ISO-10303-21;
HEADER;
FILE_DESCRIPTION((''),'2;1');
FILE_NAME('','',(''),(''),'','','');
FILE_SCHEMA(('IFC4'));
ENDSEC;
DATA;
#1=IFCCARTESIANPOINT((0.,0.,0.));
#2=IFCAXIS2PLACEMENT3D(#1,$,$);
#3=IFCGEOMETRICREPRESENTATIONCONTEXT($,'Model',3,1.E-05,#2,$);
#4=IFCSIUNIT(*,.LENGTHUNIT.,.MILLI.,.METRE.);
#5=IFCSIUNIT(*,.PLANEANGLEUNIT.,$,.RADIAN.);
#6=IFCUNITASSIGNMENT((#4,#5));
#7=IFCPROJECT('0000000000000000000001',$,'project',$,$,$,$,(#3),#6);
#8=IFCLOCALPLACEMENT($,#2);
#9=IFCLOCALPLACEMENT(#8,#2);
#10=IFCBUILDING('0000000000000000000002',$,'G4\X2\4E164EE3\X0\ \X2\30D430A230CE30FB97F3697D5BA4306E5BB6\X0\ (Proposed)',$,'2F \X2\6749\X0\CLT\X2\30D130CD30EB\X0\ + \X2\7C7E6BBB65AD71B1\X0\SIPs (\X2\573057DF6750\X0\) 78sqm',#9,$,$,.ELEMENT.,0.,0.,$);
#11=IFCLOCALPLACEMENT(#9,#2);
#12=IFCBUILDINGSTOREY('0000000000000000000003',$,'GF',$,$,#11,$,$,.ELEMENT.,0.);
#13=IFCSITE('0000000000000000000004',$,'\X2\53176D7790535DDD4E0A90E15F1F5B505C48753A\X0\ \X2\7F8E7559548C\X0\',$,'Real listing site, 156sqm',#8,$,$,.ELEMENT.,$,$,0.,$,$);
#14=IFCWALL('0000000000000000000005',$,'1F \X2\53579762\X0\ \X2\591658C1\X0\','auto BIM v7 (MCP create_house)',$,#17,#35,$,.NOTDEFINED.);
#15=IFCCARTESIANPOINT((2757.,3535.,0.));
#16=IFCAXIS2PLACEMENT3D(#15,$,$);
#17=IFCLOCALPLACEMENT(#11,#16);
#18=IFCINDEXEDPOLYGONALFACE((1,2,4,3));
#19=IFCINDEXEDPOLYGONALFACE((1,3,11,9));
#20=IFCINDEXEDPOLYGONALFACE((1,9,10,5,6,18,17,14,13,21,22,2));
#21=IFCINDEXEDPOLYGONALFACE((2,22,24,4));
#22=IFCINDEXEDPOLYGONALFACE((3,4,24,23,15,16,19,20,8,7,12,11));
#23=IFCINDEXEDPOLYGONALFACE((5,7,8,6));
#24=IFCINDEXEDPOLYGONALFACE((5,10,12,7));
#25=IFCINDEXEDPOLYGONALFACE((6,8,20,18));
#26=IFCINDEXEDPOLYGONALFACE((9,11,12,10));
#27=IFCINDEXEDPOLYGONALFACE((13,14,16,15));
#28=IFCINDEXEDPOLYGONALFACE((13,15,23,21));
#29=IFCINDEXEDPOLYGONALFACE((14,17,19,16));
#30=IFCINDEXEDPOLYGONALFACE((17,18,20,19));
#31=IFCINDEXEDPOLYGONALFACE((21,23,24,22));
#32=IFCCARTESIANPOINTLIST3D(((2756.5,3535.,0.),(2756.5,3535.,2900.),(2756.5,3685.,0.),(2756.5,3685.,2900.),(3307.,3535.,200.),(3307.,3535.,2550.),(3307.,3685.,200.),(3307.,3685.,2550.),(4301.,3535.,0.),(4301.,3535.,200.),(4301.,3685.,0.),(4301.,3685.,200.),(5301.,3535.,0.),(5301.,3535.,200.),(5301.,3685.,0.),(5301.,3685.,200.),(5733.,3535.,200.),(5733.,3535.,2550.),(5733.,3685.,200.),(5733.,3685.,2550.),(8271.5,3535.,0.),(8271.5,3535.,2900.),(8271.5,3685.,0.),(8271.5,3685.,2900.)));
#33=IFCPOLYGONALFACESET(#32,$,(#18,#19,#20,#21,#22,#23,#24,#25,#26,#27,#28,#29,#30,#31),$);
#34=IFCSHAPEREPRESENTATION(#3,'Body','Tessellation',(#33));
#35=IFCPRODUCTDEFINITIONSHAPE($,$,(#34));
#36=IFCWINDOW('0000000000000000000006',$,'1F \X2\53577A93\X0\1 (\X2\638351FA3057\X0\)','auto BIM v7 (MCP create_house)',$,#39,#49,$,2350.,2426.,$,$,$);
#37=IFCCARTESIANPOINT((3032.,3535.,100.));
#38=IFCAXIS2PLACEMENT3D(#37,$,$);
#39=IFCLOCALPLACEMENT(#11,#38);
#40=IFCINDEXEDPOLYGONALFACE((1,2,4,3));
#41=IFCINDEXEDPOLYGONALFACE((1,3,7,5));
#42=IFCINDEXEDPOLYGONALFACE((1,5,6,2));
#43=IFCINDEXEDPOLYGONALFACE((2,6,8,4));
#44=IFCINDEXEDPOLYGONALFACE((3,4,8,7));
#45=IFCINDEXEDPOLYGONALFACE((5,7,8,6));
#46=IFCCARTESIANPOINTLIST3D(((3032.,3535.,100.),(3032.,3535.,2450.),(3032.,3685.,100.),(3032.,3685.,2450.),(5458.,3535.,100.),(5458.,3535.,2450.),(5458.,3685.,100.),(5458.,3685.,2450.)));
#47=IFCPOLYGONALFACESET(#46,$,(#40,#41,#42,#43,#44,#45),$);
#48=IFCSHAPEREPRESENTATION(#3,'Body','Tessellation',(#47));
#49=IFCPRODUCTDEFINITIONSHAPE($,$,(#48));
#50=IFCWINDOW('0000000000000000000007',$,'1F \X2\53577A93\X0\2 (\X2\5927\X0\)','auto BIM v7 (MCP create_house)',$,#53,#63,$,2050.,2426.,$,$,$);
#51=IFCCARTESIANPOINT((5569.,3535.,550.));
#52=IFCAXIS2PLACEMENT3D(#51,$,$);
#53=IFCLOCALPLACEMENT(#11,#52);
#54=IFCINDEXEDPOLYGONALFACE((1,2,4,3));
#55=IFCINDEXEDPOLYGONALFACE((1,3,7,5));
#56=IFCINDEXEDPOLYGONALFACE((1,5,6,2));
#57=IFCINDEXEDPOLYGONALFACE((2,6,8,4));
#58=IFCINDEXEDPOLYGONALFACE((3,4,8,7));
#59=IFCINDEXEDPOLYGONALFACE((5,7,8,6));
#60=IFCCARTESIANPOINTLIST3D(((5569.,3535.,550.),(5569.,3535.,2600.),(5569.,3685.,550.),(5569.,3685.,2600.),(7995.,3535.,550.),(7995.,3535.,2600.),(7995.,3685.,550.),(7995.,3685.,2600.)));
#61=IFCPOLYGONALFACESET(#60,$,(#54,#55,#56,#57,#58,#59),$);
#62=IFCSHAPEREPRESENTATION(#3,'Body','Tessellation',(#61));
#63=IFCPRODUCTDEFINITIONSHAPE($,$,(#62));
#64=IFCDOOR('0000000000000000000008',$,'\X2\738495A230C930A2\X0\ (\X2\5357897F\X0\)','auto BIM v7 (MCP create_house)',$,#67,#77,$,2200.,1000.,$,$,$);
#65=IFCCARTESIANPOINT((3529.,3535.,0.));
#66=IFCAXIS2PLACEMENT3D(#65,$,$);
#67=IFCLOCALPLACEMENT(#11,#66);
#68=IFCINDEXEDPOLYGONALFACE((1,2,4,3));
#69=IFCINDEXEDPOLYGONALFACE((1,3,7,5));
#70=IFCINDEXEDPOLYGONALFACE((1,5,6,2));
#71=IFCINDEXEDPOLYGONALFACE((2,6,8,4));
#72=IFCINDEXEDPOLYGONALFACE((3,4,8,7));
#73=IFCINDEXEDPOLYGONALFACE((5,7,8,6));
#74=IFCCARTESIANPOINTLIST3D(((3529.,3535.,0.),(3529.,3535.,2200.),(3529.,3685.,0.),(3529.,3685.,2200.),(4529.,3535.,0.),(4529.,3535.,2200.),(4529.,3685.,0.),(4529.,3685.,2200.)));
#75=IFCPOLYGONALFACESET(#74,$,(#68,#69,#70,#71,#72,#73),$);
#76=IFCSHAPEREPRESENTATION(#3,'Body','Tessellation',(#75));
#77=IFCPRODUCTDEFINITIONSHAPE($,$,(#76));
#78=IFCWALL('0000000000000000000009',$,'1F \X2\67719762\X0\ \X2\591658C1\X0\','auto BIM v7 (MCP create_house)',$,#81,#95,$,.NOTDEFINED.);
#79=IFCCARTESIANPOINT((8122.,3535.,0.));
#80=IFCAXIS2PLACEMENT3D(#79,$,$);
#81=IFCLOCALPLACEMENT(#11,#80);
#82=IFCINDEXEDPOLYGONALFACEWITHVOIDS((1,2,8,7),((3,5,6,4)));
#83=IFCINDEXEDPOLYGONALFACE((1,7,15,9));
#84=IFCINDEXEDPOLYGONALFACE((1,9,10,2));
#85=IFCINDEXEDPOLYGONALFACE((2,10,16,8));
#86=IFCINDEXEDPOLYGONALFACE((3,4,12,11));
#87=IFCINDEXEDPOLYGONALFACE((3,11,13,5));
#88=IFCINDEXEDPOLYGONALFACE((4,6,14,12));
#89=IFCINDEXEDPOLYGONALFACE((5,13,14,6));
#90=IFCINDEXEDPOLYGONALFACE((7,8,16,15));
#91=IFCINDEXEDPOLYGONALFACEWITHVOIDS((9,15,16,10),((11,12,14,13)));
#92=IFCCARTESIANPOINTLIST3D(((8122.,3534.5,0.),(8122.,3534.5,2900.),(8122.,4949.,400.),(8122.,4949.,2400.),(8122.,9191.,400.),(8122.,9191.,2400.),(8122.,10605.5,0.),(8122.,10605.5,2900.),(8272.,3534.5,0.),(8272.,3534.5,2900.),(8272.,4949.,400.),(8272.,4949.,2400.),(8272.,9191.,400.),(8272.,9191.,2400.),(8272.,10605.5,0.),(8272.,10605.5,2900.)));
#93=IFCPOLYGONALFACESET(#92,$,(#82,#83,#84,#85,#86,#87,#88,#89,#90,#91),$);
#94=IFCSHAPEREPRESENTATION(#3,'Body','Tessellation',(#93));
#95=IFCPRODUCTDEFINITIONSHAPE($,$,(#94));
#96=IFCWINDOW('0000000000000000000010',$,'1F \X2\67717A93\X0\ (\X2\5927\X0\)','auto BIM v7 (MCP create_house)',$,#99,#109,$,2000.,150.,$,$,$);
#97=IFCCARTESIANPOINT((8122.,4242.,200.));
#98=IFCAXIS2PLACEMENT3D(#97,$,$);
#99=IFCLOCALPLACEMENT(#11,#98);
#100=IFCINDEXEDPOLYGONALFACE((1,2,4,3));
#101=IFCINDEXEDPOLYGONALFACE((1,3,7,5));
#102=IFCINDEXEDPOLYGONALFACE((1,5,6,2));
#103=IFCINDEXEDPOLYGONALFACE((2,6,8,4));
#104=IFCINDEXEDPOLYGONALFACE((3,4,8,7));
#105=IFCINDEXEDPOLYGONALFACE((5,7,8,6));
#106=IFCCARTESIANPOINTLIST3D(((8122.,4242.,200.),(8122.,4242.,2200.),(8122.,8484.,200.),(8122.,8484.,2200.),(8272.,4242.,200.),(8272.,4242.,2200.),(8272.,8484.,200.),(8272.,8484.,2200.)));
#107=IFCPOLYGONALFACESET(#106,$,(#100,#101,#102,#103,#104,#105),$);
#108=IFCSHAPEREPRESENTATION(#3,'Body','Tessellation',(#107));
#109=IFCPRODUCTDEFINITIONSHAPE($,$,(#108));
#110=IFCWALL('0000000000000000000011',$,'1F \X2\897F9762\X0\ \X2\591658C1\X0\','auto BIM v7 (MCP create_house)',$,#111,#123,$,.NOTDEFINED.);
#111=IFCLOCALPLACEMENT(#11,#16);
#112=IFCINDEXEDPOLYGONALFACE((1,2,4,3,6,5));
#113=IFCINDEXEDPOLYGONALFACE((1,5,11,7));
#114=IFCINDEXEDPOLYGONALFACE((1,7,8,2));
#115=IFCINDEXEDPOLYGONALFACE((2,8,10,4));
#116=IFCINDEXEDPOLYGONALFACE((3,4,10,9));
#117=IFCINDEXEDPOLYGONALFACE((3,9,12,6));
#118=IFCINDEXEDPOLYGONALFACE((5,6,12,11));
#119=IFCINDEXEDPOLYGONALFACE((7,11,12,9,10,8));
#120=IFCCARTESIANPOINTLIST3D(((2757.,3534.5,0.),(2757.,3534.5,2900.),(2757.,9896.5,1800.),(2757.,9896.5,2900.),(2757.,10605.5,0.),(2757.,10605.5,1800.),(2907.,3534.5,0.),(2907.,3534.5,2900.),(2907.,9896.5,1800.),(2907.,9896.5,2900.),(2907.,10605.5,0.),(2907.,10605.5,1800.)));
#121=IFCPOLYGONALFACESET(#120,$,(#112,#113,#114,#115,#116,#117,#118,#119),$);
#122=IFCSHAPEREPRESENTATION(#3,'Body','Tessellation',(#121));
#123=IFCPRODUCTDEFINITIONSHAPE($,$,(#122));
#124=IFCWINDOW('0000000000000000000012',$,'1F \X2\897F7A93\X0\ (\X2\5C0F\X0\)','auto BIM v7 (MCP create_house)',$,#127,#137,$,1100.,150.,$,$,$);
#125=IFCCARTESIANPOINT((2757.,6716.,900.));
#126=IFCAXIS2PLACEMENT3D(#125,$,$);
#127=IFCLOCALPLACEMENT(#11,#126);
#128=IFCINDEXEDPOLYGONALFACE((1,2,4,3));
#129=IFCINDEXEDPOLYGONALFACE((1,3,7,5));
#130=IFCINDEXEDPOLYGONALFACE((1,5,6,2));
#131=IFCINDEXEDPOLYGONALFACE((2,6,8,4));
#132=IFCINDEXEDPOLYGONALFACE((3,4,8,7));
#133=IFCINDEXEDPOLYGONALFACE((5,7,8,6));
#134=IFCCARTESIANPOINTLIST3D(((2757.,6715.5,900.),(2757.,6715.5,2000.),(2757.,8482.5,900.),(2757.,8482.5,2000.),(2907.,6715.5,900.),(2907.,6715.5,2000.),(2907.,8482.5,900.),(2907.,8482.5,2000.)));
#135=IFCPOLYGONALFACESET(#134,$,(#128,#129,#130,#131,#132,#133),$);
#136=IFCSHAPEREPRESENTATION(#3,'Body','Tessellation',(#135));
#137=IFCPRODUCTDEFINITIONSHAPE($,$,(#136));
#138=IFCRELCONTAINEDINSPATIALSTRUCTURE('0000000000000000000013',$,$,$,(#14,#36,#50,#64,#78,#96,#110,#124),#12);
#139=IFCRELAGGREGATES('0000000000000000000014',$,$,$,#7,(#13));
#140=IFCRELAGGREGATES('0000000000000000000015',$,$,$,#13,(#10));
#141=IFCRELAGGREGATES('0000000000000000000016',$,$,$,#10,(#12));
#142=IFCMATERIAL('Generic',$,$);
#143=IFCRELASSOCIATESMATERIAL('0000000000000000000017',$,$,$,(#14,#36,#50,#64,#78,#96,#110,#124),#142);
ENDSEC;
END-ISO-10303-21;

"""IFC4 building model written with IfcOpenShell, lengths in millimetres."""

from ifc_helpers import new_model, si_unit, frame, frame_2d, origin, place, context, project, spatial, rectangle, extrude, material, element, fill, save


model = new_model("IFC4")

# Units and contexts
model_context = context("Model", 3, precision=1e-05, world=origin())
ifc_project = project(units=[si_unit("LENGTHUNIT", "METRE", prefix="MILLI"), si_unit("PLANEANGLEUNIT", "RADIAN")], contexts=[model_context])

# Site, building, storey
site_placement = place(None, origin())
site = spatial("IfcSite", under=ifc_project, at=site_placement, Name="北海道川上郡弟子屈町 美留和", ObjectType="Real listing site, 156sqm", CompositionType="ELEMENT", RefElevation=0.0)
building_placement = place(site_placement, origin())
building = spatial("IfcBuilding", under=site, at=building_placement, Name="G4世代 ピアノ・音楽室の家 (Proposed)", ObjectType="2F 杉CLTパネル + 籾殻断熱SIPs (地域材) 78sqm", CompositionType="ELEMENT", ElevationOfRefHeight=0.0, ElevationOfTerrain=0.0)
storey_placement = place(building_placement, origin())
storey = spatial("IfcBuildingStorey", under=building, at=storey_placement, Name="GF", CompositionType="ELEMENT", Elevation=0.0)

# Shared definitions
ifc_material = material(Name="Generic")

# Wall, openings, windows, door
wall_1_placement = place(storey_placement, frame((2757.0, 3535.0, 0.0)))
wall_1 = element("IfcWall", 1, at=wall_1_placement, inside=storey, material=ifc_material, Name="1F 南面 外壁", Description="auto BIM v7 (MCP create_house)", PredefinedType="NOTDEFINED", context=model_context, shape_type="SweptSolid", body=[
    extrude(rectangle(XDim=5515.0, YDim=150.0, at=frame_2d((2757.0, 75.0))), frame((2757.0, 3535.0, 0.0)), (0.0, 0.0, 1.0), 2900.0),
])
opening_1_placement = place(storey_placement, frame((3032.0, 3535.0, 100.0)))
opening_1 = element("IfcOpeningElement", 2, at=opening_1_placement, cuts=wall_1, PredefinedType="NOTDEFINED", context=model_context, shape_type="SweptSolid", body=[
    extrude(rectangle(XDim=2426.0, YDim=150.0, at=frame_2d((1213.0, 75.0))), frame((3032.0, 3535.0, 100.0)), (0.0, 0.0, 1.0), 2350.0),
])
opening_2_placement = place(storey_placement, frame((5569.0, 3535.0, 550.0)))
opening_2 = element("IfcOpeningElement", 3, at=opening_2_placement, cuts=wall_1, PredefinedType="NOTDEFINED", context=model_context, shape_type="SweptSolid", body=[
    extrude(rectangle(XDim=2426.0, YDim=150.0, at=frame_2d((1213.0, 75.0))), frame((5569.0, 3535.0, 550.0)), (0.0, 0.0, 1.0), 2050.0),
])
opening_3_placement = place(storey_placement, frame((3529.0, 3535.0, 0.0)))
opening_3 = element("IfcOpeningElement", 4, at=opening_3_placement, cuts=wall_1, PredefinedType="NOTDEFINED", context=model_context, shape_type="SweptSolid", body=[
    extrude(rectangle(XDim=1000.0, YDim=150.0, at=frame_2d((500.0, 75.0))), frame((3529.0, 3535.0, 0.0)), (0.0, 0.0, 1.0), 2200.0),
])
window_1_placement = place(storey_placement, frame((3032.0, 3535.0, 100.0)))
window_1 = element("IfcWindow", 5, at=window_1_placement, inside=storey, material=ifc_material, Name="1F 南窓1 (掃出し)", Description="auto BIM v7 (MCP create_house)", OverallHeight=2350.0, OverallWidth=2426.0, context=model_context, shape_type="SweptSolid", body=[
    extrude(rectangle(XDim=2426.0, YDim=150.0, at=frame_2d((1213.0, 75.0))), frame((3032.0, 3535.0, 100.0)), (0.0, 0.0, 1.0), 2350.0),
])
fill(opening_1, window_1)
window_2_placement = place(storey_placement, frame((5569.0, 3535.0, 550.0)))
window_2 = element("IfcWindow", 6, at=window_2_placement, inside=storey, material=ifc_material, Name="1F 南窓2 (大)", Description="auto BIM v7 (MCP create_house)", OverallHeight=2050.0, OverallWidth=2426.0, context=model_context, shape_type="SweptSolid", body=[
    extrude(rectangle(XDim=2426.0, YDim=150.0, at=frame_2d((1213.0, 75.0))), frame((5569.0, 3535.0, 550.0)), (0.0, 0.0, 1.0), 2050.0),
])
fill(opening_2, window_2)
door_placement = place(storey_placement, frame((3529.0, 3535.0, 0.0)))
door = element("IfcDoor", 7, at=door_placement, inside=storey, material=ifc_material, Name="玄関ドア (南西)", Description="auto BIM v7 (MCP create_house)", OverallHeight=2200.0, OverallWidth=1000.0, context=model_context, shape_type="SweptSolid", body=[
    extrude(rectangle(XDim=1000.0, YDim=150.0, at=frame_2d((500.0, 75.0))), frame((3529.0, 3535.0, 0.0)), (0.0, 0.0, 1.0), 2200.0),
])
fill(opening_3, door)

# Walls, openings, windows
wall_2_placement = place(storey_placement, frame((8122.0, 3535.0, 0.0)))
wall_2 = element("IfcWall", 8, at=wall_2_placement, inside=storey, material=ifc_material, Name="1F 東面 外壁", Description="auto BIM v7 (MCP create_house)", PredefinedType="NOTDEFINED", context=model_context, shape_type="SweptSolid", body=[
    extrude(rectangle(XDim=150.0, YDim=7071.0, at=frame_2d((75.0, 3535.0))), frame((8122.0, 3535.0, 0.0)), (0.0, 0.0, 1.0), 2900.0),
])
opening_4_placement = place(storey_placement, frame((8122.0, 4242.0, 200.0)))
opening_4 = element("IfcOpeningElement", 9, at=opening_4_placement, cuts=wall_2, PredefinedType="NOTDEFINED", context=model_context, shape_type="SweptSolid", body=[
    extrude(rectangle(XDim=150.0, YDim=4242.0, at=frame_2d((75.0, 2121.0))), frame((8122.0, 4242.0, 200.0)), (0.0, 0.0, 1.0), 2000.0),
])
window_3_placement = place(storey_placement, frame((8122.0, 4242.0, 200.0)))
window_3 = element("IfcWindow", 10, at=window_3_placement, inside=storey, material=ifc_material, Name="1F 東窓 (大)", Description="auto BIM v7 (MCP create_house)", OverallHeight=2000.0, OverallWidth=150.0, context=model_context, shape_type="SweptSolid", body=[
    extrude(rectangle(XDim=150.0, YDim=4242.0, at=frame_2d((75.0, 2121.0))), frame((8122.0, 4242.0, 200.0)), (0.0, 0.0, 1.0), 2000.0),
])
fill(opening_4, window_3)
wall_3_placement = place(storey_placement, frame((2757.0, 3535.0, 0.0)))
wall_3 = element("IfcWall", 11, at=wall_3_placement, inside=storey, material=ifc_material, Name="1F 西面 外壁", Description="auto BIM v7 (MCP create_house)", PredefinedType="NOTDEFINED", context=model_context, shape_type="SweptSolid", body=[
    extrude(rectangle(XDim=150.0, YDim=7071.0, at=frame_2d((75.0, 3535.0))), frame((2757.0, 3535.0, 0.0)), (0.0, 0.0, 1.0), 2900.0),
])
opening_5_placement = place(storey_placement, frame((2757.0, 6716.0, 900.0)))
opening_5 = element("IfcOpeningElement", 12, at=opening_5_placement, cuts=wall_3, PredefinedType="NOTDEFINED", context=model_context, shape_type="SweptSolid", body=[
    extrude(rectangle(XDim=150.0, YDim=1767.0, at=frame_2d((75.0, 883.0))), frame((2757.0, 6716.0, 900.0)), (0.0, 0.0, 1.0), 1100.0),
])
window_4_placement = place(storey_placement, frame((2757.0, 6716.0, 900.0)))
window_4 = element("IfcWindow", 13, at=window_4_placement, inside=storey, material=ifc_material, Name="1F 西窓 (小)", Description="auto BIM v7 (MCP create_house)", OverallHeight=1100.0, OverallWidth=150.0, context=model_context, shape_type="SweptSolid", body=[
    extrude(rectangle(XDim=150.0, YDim=1767.0, at=frame_2d((75.0, 883.0))), frame((2757.0, 6716.0, 900.0)), (0.0, 0.0, 1.0), 1100.0),
])
fill(opening_5, window_4)

save(model, "model.ifc")
